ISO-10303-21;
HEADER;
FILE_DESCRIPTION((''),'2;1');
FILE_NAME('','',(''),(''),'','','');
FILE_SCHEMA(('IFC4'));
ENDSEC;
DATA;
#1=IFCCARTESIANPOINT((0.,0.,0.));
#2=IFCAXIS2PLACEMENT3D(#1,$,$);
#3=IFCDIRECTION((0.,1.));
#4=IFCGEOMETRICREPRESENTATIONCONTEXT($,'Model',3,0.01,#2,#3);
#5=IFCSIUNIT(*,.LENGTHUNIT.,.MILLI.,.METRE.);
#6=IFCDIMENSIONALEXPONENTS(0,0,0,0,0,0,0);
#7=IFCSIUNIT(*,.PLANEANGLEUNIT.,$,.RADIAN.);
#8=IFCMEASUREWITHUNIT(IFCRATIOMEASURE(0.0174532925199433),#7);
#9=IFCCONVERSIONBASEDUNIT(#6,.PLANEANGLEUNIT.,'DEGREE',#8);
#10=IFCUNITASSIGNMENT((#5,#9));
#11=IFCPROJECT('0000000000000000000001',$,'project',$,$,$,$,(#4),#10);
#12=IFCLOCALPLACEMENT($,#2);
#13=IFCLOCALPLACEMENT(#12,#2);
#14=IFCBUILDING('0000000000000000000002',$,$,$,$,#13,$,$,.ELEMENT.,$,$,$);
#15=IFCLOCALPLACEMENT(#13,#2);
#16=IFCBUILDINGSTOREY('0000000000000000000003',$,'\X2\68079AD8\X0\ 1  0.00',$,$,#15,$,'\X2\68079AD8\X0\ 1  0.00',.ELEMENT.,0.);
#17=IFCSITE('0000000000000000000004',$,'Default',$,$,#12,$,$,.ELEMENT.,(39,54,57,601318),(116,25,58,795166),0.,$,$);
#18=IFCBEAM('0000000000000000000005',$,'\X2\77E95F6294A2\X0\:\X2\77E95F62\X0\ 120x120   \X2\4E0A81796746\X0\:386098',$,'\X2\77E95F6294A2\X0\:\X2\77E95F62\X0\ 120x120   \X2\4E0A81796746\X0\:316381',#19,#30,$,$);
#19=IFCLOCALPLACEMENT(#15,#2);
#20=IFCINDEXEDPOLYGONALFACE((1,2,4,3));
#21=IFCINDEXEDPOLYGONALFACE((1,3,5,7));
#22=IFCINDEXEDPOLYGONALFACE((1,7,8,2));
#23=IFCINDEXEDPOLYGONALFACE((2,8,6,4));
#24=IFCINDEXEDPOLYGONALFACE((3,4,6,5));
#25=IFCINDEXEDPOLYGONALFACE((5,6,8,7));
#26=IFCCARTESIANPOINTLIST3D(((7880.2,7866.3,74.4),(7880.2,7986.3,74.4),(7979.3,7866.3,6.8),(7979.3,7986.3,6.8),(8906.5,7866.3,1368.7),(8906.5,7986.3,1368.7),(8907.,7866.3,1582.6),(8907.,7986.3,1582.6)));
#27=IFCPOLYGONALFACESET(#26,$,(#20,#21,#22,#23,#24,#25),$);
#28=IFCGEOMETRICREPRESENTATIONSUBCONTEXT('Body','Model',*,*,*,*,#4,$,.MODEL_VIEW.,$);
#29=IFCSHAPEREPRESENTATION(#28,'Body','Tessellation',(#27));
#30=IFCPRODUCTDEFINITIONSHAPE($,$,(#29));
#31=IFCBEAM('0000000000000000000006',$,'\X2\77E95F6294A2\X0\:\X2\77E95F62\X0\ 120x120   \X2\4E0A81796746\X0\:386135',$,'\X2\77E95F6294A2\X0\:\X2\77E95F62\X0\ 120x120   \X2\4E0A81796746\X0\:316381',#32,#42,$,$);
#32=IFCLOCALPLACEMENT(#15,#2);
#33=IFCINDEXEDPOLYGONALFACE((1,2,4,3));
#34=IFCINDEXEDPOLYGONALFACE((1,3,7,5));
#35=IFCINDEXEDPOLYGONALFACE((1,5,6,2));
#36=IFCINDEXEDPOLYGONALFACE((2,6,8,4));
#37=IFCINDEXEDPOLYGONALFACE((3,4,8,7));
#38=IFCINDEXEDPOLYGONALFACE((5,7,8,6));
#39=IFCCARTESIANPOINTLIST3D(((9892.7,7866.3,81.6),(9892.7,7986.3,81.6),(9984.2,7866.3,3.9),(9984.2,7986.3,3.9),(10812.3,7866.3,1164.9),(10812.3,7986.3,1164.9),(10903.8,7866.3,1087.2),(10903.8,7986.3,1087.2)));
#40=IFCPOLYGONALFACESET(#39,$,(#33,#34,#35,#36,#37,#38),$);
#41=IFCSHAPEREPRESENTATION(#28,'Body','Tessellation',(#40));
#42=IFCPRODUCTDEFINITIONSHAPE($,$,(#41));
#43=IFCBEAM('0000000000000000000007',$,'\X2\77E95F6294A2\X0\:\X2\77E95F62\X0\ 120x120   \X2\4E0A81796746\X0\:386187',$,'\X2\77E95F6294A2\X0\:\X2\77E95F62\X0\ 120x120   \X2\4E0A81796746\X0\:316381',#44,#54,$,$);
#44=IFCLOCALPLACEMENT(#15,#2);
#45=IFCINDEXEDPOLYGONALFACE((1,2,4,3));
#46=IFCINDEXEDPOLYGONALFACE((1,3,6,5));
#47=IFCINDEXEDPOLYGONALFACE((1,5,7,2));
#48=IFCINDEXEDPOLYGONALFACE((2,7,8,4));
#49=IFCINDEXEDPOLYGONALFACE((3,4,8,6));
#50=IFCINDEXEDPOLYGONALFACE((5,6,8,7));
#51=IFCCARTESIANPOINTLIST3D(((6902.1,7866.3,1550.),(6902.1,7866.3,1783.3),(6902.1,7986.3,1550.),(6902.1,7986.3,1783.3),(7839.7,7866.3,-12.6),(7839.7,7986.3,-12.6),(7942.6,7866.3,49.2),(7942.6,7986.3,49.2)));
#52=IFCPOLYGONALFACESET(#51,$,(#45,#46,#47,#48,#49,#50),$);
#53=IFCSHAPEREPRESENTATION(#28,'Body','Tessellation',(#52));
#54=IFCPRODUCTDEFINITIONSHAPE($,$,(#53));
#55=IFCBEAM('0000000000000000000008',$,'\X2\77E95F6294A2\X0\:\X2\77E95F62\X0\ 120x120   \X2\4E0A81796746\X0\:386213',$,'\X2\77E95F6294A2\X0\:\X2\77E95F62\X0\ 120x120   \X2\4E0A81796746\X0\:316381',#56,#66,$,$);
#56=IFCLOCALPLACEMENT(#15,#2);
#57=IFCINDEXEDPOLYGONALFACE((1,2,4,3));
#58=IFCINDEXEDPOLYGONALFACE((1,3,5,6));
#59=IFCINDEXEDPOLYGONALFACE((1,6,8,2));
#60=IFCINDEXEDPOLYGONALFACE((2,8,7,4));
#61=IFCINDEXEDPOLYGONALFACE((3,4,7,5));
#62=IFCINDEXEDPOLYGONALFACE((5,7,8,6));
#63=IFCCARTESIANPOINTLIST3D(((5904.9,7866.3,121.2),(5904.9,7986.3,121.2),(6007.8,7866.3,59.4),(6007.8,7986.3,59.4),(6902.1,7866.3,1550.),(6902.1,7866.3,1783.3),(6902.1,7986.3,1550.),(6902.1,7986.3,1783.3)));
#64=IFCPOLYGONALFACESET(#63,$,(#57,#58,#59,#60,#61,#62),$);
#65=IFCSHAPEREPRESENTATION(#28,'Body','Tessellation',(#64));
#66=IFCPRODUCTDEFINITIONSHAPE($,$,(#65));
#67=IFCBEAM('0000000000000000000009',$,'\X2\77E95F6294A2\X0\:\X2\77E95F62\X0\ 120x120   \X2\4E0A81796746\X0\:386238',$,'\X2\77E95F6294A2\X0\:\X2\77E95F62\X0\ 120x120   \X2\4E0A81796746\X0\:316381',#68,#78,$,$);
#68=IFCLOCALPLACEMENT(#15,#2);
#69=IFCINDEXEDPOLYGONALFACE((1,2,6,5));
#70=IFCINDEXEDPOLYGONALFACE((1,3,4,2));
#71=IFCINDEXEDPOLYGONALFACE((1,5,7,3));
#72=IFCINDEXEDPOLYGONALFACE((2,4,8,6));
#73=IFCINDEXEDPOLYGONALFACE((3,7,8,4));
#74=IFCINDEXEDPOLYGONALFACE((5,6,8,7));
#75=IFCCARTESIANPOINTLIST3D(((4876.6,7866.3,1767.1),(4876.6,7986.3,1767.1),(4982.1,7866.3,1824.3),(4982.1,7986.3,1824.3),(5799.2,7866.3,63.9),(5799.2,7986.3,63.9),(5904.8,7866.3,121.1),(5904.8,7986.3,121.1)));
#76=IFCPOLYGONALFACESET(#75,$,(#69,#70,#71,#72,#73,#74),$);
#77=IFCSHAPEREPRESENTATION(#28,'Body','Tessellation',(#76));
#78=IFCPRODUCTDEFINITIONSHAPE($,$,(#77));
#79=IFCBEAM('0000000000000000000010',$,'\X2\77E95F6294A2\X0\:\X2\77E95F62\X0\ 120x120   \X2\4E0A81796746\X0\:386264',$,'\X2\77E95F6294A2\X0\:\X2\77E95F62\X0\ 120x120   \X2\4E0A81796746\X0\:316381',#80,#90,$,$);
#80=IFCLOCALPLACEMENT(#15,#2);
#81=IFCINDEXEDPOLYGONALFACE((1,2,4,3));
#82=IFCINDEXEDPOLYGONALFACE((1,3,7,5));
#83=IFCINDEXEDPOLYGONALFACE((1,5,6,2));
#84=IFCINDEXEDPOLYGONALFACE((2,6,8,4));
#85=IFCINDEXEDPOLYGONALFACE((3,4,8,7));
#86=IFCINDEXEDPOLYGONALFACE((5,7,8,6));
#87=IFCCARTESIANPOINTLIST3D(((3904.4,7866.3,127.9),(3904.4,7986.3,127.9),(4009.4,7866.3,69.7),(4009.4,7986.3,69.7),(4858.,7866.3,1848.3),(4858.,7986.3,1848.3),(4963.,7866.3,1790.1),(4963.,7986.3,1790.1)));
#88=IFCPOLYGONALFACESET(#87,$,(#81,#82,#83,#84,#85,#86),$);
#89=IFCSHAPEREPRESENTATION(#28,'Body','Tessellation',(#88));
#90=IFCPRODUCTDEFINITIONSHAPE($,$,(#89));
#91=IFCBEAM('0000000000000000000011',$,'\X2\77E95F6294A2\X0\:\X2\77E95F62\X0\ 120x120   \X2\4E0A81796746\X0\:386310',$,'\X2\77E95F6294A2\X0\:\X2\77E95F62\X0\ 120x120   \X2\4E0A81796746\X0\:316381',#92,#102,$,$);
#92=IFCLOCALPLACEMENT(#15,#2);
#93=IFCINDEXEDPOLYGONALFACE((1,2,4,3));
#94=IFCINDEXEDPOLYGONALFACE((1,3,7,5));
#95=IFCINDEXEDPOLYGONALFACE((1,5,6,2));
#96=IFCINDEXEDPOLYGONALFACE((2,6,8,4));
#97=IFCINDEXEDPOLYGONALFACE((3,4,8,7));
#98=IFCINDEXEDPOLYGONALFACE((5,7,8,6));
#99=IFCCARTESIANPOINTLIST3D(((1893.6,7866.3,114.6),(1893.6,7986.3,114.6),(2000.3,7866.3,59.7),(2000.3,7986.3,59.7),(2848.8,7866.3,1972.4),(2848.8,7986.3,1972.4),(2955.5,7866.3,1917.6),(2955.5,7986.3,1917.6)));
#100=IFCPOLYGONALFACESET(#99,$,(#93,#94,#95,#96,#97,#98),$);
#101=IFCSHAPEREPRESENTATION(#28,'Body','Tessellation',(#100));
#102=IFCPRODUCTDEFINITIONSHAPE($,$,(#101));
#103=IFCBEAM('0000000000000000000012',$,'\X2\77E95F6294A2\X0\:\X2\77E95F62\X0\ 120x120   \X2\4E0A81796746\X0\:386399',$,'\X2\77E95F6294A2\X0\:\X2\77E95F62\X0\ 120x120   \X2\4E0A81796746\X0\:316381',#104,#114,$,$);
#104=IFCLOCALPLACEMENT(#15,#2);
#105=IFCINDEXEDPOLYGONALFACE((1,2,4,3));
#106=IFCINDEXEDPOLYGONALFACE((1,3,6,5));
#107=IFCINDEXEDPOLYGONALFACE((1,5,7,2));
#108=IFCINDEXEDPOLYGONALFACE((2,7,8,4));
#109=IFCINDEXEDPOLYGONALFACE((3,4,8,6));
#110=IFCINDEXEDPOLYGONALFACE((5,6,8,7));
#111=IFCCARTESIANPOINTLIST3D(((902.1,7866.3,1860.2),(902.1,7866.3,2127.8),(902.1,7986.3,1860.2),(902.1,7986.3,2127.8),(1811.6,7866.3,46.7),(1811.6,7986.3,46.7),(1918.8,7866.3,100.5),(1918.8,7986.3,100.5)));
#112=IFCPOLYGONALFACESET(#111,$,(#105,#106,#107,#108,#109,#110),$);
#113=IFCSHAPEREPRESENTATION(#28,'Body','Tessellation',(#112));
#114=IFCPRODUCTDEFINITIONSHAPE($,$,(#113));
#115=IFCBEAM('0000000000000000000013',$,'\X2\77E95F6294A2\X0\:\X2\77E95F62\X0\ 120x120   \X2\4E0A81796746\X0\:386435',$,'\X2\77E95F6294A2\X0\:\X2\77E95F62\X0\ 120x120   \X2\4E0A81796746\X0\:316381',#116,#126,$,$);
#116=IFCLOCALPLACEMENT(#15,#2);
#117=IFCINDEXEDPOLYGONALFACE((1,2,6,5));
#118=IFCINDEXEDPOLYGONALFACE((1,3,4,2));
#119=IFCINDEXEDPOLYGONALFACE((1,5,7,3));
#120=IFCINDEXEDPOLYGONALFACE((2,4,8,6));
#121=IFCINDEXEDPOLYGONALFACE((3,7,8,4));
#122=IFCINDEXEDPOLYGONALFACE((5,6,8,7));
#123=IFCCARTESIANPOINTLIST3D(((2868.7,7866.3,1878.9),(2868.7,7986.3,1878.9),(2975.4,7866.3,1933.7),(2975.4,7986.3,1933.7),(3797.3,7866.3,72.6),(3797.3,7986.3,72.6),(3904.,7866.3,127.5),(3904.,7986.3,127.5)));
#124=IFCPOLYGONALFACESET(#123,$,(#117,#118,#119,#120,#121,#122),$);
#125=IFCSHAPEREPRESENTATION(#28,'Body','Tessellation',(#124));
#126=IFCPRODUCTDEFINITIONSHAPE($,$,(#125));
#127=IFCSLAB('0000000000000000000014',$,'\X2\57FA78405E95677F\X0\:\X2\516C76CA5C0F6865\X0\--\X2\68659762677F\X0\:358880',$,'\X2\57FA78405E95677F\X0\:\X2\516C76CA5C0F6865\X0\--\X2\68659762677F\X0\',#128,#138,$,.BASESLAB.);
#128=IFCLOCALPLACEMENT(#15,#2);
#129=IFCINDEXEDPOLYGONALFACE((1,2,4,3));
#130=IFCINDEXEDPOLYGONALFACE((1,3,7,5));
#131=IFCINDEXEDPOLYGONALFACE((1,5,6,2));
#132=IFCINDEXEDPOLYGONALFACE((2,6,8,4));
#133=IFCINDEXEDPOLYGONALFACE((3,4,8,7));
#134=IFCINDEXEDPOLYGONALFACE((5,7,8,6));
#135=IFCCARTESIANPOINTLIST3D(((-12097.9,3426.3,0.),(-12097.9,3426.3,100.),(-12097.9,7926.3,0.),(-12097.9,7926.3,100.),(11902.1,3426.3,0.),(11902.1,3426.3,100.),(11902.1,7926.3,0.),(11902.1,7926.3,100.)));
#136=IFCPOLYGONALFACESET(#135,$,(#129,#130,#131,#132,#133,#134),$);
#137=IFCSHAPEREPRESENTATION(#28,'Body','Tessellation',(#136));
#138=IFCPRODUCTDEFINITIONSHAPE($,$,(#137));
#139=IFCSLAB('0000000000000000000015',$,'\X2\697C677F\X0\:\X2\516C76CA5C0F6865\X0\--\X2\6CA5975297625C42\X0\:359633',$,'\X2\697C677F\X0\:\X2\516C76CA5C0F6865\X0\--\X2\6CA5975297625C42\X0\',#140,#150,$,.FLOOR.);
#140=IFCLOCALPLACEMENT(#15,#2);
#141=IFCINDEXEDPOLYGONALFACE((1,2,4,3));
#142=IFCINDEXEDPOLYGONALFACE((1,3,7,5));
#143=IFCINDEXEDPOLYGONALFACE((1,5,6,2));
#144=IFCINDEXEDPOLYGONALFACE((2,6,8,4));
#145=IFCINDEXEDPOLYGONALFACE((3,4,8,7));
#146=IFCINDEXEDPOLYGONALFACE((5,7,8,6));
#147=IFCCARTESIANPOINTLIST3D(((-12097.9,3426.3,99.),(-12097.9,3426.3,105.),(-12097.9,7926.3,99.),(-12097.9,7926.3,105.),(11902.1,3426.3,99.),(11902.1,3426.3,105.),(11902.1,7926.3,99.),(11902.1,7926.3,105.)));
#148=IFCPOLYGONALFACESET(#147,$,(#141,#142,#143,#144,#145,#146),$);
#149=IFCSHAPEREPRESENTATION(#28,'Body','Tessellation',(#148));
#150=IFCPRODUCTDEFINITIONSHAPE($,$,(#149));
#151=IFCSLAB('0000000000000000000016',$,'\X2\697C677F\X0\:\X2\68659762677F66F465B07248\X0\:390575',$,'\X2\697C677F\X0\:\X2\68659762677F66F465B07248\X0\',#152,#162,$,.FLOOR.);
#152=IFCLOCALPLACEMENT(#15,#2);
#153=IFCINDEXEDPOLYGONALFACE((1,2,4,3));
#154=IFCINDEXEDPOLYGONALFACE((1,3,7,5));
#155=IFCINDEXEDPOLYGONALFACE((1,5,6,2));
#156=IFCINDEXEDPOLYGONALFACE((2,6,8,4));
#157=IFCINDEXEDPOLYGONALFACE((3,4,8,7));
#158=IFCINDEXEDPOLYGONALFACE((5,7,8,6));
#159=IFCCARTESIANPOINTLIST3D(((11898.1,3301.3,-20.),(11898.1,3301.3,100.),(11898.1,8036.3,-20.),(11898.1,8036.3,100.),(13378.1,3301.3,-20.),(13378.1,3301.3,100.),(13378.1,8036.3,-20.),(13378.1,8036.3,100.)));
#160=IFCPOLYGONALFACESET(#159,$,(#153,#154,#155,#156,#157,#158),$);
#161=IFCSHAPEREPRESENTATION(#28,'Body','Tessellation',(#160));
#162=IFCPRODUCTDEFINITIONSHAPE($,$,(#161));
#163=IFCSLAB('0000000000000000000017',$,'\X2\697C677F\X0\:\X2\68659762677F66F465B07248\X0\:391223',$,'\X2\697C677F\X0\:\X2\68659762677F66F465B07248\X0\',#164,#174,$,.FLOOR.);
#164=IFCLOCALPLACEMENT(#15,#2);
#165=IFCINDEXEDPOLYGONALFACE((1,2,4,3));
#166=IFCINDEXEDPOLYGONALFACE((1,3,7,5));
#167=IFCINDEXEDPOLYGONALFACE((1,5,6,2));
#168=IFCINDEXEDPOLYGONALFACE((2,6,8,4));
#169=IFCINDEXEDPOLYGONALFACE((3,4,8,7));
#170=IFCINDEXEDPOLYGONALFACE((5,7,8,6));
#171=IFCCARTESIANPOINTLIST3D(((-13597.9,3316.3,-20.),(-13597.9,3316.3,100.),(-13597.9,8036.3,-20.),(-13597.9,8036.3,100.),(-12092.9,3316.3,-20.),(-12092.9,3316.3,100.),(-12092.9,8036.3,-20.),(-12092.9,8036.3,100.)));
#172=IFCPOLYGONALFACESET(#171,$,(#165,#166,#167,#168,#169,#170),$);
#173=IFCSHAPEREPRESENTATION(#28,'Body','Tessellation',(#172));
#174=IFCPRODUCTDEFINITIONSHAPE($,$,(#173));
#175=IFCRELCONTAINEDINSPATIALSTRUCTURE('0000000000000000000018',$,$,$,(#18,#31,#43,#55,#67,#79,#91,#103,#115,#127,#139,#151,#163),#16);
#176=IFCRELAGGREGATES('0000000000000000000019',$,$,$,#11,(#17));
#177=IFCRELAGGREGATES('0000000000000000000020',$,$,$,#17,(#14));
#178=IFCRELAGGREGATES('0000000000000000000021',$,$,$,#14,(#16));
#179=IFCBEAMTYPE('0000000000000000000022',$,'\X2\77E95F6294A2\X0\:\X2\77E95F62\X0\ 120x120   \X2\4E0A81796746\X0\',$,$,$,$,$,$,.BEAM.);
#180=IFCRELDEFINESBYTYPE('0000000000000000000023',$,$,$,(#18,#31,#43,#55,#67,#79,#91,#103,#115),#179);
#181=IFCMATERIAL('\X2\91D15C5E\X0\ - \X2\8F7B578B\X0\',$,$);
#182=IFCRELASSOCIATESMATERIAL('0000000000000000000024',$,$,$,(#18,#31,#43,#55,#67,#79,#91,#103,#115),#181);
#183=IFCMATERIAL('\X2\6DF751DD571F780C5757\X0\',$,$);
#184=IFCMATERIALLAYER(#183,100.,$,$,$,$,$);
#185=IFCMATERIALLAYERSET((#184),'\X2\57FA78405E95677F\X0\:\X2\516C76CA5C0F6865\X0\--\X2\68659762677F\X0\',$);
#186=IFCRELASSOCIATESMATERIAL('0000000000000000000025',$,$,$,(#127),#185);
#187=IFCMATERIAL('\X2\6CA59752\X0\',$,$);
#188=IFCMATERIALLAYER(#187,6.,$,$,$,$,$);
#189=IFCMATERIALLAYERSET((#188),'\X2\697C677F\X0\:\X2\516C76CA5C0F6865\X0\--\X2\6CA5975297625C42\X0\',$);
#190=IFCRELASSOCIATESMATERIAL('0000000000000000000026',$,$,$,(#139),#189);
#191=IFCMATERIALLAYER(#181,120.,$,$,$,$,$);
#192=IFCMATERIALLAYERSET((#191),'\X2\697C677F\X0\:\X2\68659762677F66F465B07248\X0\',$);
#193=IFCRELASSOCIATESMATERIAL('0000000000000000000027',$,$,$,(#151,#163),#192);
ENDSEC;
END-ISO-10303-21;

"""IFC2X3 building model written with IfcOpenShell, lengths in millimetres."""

from ifc_helpers import new_model, entity, si_unit, converted_unit, direction, frame, frame_2d, origin, origin_2d_with_axis, place, context, subcontext, project, spatial, rectangle, extrude, clip, halfspace, material, layer, layer_set, layer_usage, type_object, element, save


model = new_model("IFC2X3")

# Units and contexts
model_context = context("Model", 3, precision=0.01, world=origin(), true_north=direction((0.0, 1.0)))
body_context = subcontext(model_context, "Body", "Model", "MODEL_VIEW")
ifc_project = project(units=[si_unit("LENGTHUNIT", "METRE", prefix="MILLI"), converted_unit("PLANEANGLEUNIT", "DEGREE", entity("IfcRatioMeasure", 0.0174532925199433), si_unit("PLANEANGLEUNIT", "RADIAN"), dimensions=[0, 0, 0, 0, 0, 0, 0])], contexts=[model_context])

# Site, building, storey
site_placement = place(None, origin())
site = spatial("IfcSite", under=ifc_project, at=site_placement, Name="Default", CompositionType="ELEMENT", RefLatitude=(39, 54, 57, 601318), RefLongitude=(116, 25, 58, 795166), RefElevation=0.0)
building_placement = place(site_placement, origin())
building = spatial("IfcBuilding", under=site, at=building_placement, CompositionType="ELEMENT")
storey_placement = place(building_placement, origin())
storey = spatial("IfcBuildingStorey", under=building, at=storey_placement, Name="标高 1  0.00", LongName="标高 1  0.00", CompositionType="ELEMENT", Elevation=0.0)

# Shared definitions
ifc_material_1 = material(Name="金属 - 轻型")

# Beams
beam_type_1 = type_object("IfcBeamType", Name="矩形钢:矩形 120x120   上腹杆", PredefinedType="BEAM")
beam_1_placement = place(storey_placement, frame((7902.1, 7926.3, 0.0), z_axis=(0.826622, 0.0, -0.562758), x_axis=(0.562758, 0.0, 0.826622)))
element("IfcBeam", 1, at=beam_1_placement, inside=storey, type_object=beam_type_1, material=ifc_material_1, Name="矩形钢:矩形 120x120   上腹杆:386098", ObjectType="矩形钢:矩形 120x120   上腹杆:316381", context=body_context, shape_type="Clipping", body=[
    clip(extrude(rectangle(XDim=120.0, YDim=120.0, at=frame_2d((0.0, 0.0), x_axis=(1.0, 0.0))), frame((49.1, 0.0, 0.0), z_axis=(1.0, 0.0, 0.0), x_axis=(0.0, 0.0, -1.0)), (0.0, 0.0, 1.0), 1824.6), halfspace(frame((1696.7, 0.0, 60.0), z_axis=(0.560977, 0.0, 0.827832), x_axis=(0.827832, 0.0, -0.560977)), False)),
])
beam_2_placement = place(storey_placement, frame((9902.1, 7926.3, 0.0), z_axis=(0.762354, 0.0, -0.64716), x_axis=(0.64716, 0.0, 0.762354)))
element("IfcBeam", 2, at=beam_2_placement, inside=storey, type_object=beam_type_1, material=ifc_material_1, Name="矩形钢:矩形 120x120   上腹杆:386135", ObjectType="矩形钢:矩形 120x120   上腹杆:316381", context=body_context, shape_type="SweptSolid", body=[
    extrude(rectangle(XDim=120.0, YDim=120.0, at=frame_2d((0.0, 0.0), x_axis=(1.0, 0.0))), frame((56.1, 0.0, 0.0), z_axis=(1.0, 0.0, 0.0), x_axis=(0.0, 0.0, -1.0)), (0.0, 0.0, 1.0), 1421.0),
])
beam_3_placement = place(storey_placement, frame((7902.1, 7926.3, 0.0), z_axis=(0.857493, 0.0, 0.514496), x_axis=(-0.514496, 0.0, 0.857493)))
element("IfcBeam", 3, at=beam_3_placement, inside=storey, type_object=beam_type_1, material=ifc_material_1, Name="矩形钢:矩形 120x120   上腹杆:386187", ObjectType="矩形钢:矩形 120x120   上腹杆:316381", context=body_context, shape_type="Clipping", body=[
    clip(extrude(rectangle(XDim=120.0, YDim=120.0, at=frame_2d((0.0, 0.0), x_axis=(1.0, 0.0))), frame((21.3, 0.0, 0.0), z_axis=(1.0, 0.0, 0.0), x_axis=(0.0, 0.0, -1.0)), (0.0, 0.0, 1.0), 2022.3), halfspace(frame((1843.7, 0.0, -60.0), z_axis=(0.514496, 0.0, -0.857493), x_axis=(0.0, -1.0, 0.0)), False)),
])
beam_4_placement = place(storey_placement, frame((5902.1, 7926.3, 0.0), z_axis=(0.857493, 0.0, -0.514496), x_axis=(0.514496, 0.0, 0.857493)))
element("IfcBeam", 4, at=beam_4_placement, inside=storey, type_object=beam_type_1, material=ifc_material_1, Name="矩形钢:矩形 120x120   上腹杆:386213", ObjectType="矩形钢:矩形 120x120   上腹杆:316381", context=body_context, shape_type="Clipping", body=[
    clip(extrude(rectangle(XDim=120.0, YDim=120.0, at=frame_2d((0.0, 0.0), x_axis=(1.0, 0.0))), frame((105.3, 0.0, 0.0), z_axis=(1.0, 0.0, 0.0), x_axis=(0.0, 0.0, -1.0)), (0.0, 0.0, 1.0), 1938.3), halfspace(frame((1843.7, 0.0, 60.0), z_axis=(0.514496, 0.0, 0.857493), x_axis=(0.0, 1.0, 0.0)), False)),
])
beam_5_placement = place(storey_placement, frame((4902.1, 7926.3, 1846.0), z_axis=(0.879275, 0.0, 0.476314), x_axis=(0.476314, 0.0, -0.879275)))
element("IfcBeam", 5, at=beam_5_placement, inside=storey, type_object=beam_type_1, material=ifc_material_1, Name="矩形钢:矩形 120x120   上腹杆:386238", ObjectType="矩形钢:矩形 120x120   上腹杆:316381", context=body_context, shape_type="SweptSolid", body=[
    extrude(rectangle(XDim=120.0, YDim=120.0, at=frame_2d((0.0, 0.0), x_axis=(1.0, 0.0))), frame((57.2, 0.0, 0.0), z_axis=(1.0, 0.0, 0.0), x_axis=(0.0, 0.0, -1.0)), (0.0, 0.0, 1.0), 1937.0),
])
beam_6_placement = place(storey_placement, frame((3902.1, 7926.3, 0.0), z_axis=(0.87462, 0.0, -0.48481), x_axis=(0.48481, 0.0, 0.87462)))
element("IfcBeam", 6, at=beam_6_placement, inside=storey, type_object=beam_type_1, material=ifc_material_1, Name="矩形钢:矩形 120x120   上腹杆:386264", ObjectType="矩形钢:矩形 120x120   上腹杆:316381", context=body_context, shape_type="SweptSolid", body=[
    extrude(rectangle(XDim=120.0, YDim=120.0, at=frame_2d((0.0, 0.0), x_axis=(1.0, 0.0))), frame((113.0, 0.0, 0.0), z_axis=(1.0, 0.0, 0.0), x_axis=(0.0, 0.0, -1.0)), (0.0, 0.0, 1.0), 1967.0),
])
beam_7_placement = place(storey_placement, frame((2902.1, 7926.3, 1945.0), z_axis=(0.889341, 0.0, -0.457245), x_axis=(-0.457245, 0.0, -0.889341)))
element("IfcBeam", 7, at=beam_7_placement, inside=storey, type_object=beam_type_1, material=ifc_material_1, Name="矩形钢:矩形 120x120   上腹杆:386310", ObjectType="矩形钢:矩形 120x120   上腹杆:316381", context=body_context, shape_type="SweptSolid", body=[
    extrude(rectangle(XDim=120.0, YDim=120.0, at=origin_2d_with_axis()), frame((0.0, 0.0, 0.0), z_axis=(1.0, 0.0, 0.0), x_axis=(0.0, 0.0, -1.0)), (0.0, 0.0, 1.0), 2089.0),
])
beam_8_placement = place(storey_placement, frame((1902.1, 7926.3, 0.0), z_axis=(0.893889, 0.0, 0.448289), x_axis=(-0.448289, 0.0, 0.893889)))
element("IfcBeam", 8, at=beam_8_placement, inside=storey, type_object=beam_type_1, material=ifc_material_1, Name="矩形钢:矩形 120x120   上腹杆:386399", ObjectType="矩形钢:矩形 120x120   上腹杆:316381", context=body_context, shape_type="Clipping", body=[
    clip(extrude(rectangle(XDim=120.0, YDim=120.0, at=frame_2d((0.0, 0.0), x_axis=(1.0, 0.0))), frame((82.4, 0.0, 0.0), z_axis=(1.0, 0.0, 0.0), x_axis=(0.0, 0.0, -1.0)), (0.0, 0.0, 1.0), 2268.0), halfspace(frame((2111.1, 0.0, -60.0), z_axis=(0.448289, 0.0, -0.893889), x_axis=(0.0, -1.0, 0.0)), False)),
])
beam_9_placement = place(storey_placement, frame((3902.1, 7926.3, 0.0), z_axis=(0.889341, 0.0, 0.457245), x_axis=(-0.457245, 0.0, 0.889341)))
element("IfcBeam", 9, at=beam_9_placement, inside=storey, type_object=beam_type_1, material=ifc_material_1, Name="矩形钢:矩形 120x120   上腹杆:386435", ObjectType="矩形钢:矩形 120x120   上腹杆:316381", context=body_context, shape_type="SweptSolid", body=[
    extrude(rectangle(XDim=120.0, YDim=120.0, at=frame_2d((0.0, 0.0), x_axis=(1.0, 0.0))), frame((112.5, 0.0, 0.0), z_axis=(1.0, 0.0, 0.0), x_axis=(0.0, 0.0, -1.0)), (0.0, 0.0, 1.0), 2031.0),
])

# Slabs
ifc_material_2 = material(Name="混凝土砌块")
ifc_layer_1 = layer(ifc_material_2, 100.0)
ifc_layer_set_1 = layer_set([ifc_layer_1], Name="基础底板:公益小桥--桥面板")
ifc_layer_usage_1 = layer_usage(ifc_layer_set_1, "AXIS3", "POSITIVE", 0.0)
slab_1_placement = place(storey_placement, origin())
element("IfcSlab", 10, at=slab_1_placement, inside=storey, material=ifc_layer_usage_1, Name="基础底板:公益小桥--桥面板:358880", ObjectType="基础底板:公益小桥--桥面板", PredefinedType="BASESLAB", context=body_context, shape_type="SweptSolid", body=[
    extrude(rectangle(XDim=4500.0, YDim=24000.0, at=frame_2d((0.0, 0.0), x_axis=(1.0, 0.0))), frame((-97.9, 5676.3, 100.0), z_axis=(0.0, 0.0, -1.0), x_axis=(0.0, 1.0, 0.0)), (0.0, 0.0, 1.0), 100.0),
])
ifc_material_3 = material(Name="沥青")
ifc_layer_2 = layer(ifc_material_3, 6.0)
ifc_layer_set_2 = layer_set([ifc_layer_2], Name="楼板:公益小桥--沥青面层")
ifc_layer_usage_2 = layer_usage(ifc_layer_set_2, "AXIS3", "POSITIVE", 0.0)
slab_2_placement = place(storey_placement, origin())
element("IfcSlab", 11, at=slab_2_placement, inside=storey, material=ifc_layer_usage_2, Name="楼板:公益小桥--沥青面层:359633", ObjectType="楼板:公益小桥--沥青面层", PredefinedType="FLOOR", context=body_context, shape_type="SweptSolid", body=[
    extrude(rectangle(XDim=4500.0, YDim=24000.0, at=frame_2d((0.0, 0.0), x_axis=(1.0, 0.0))), frame((-97.9, 5676.3, 105.0), z_axis=(0.0, 0.0, -1.0), x_axis=(0.0, 1.0, 0.0)), (0.0, 0.0, 1.0), 6.0),
])
ifc_layer_3 = layer(ifc_material_1, 120.0)
ifc_layer_set_3 = layer_set([ifc_layer_3], Name="楼板:桥面板更新版")
ifc_layer_usage_3 = layer_usage(ifc_layer_set_3, "AXIS3", "POSITIVE", 0.0)
slab_3_placement = place(storey_placement, origin())
element("IfcSlab", 12, at=slab_3_placement, inside=storey, material=ifc_layer_usage_3, Name="楼板:桥面板更新版:390575", ObjectType="楼板:桥面板更新版", PredefinedType="FLOOR", context=body_context, shape_type="SweptSolid", body=[
    extrude(rectangle(XDim=4735.0, YDim=1480.0, at=frame_2d((0.0, 0.0), x_axis=(1.0, 0.0))), frame((12638.1, 5668.8, 100.0), z_axis=(0.0, 0.0, -1.0), x_axis=(0.0, -1.0, 0.0)), (0.0, 0.0, 1.0), 120.0),
])
ifc_layer_usage_4 = layer_usage(ifc_layer_set_3, "AXIS3", "POSITIVE", 0.0)
slab_4_placement = place(storey_placement, origin())
element("IfcSlab", 13, at=slab_4_placement, inside=storey, material=ifc_layer_usage_4, Name="楼板:桥面板更新版:391223", ObjectType="楼板:桥面板更新版", PredefinedType="FLOOR", context=body_context, shape_type="SweptSolid", body=[
    extrude(rectangle(XDim=4720.0, YDim=1505.0, at=frame_2d((0.0, 0.0), x_axis=(1.0, 0.0))), frame((-12845.4, 5676.3, 100.0), z_axis=(0.0, 0.0, -1.0), x_axis=(0.0, 1.0, 0.0)), (0.0, 0.0, 1.0), 120.0),
])

save(model, "model.ifc")
